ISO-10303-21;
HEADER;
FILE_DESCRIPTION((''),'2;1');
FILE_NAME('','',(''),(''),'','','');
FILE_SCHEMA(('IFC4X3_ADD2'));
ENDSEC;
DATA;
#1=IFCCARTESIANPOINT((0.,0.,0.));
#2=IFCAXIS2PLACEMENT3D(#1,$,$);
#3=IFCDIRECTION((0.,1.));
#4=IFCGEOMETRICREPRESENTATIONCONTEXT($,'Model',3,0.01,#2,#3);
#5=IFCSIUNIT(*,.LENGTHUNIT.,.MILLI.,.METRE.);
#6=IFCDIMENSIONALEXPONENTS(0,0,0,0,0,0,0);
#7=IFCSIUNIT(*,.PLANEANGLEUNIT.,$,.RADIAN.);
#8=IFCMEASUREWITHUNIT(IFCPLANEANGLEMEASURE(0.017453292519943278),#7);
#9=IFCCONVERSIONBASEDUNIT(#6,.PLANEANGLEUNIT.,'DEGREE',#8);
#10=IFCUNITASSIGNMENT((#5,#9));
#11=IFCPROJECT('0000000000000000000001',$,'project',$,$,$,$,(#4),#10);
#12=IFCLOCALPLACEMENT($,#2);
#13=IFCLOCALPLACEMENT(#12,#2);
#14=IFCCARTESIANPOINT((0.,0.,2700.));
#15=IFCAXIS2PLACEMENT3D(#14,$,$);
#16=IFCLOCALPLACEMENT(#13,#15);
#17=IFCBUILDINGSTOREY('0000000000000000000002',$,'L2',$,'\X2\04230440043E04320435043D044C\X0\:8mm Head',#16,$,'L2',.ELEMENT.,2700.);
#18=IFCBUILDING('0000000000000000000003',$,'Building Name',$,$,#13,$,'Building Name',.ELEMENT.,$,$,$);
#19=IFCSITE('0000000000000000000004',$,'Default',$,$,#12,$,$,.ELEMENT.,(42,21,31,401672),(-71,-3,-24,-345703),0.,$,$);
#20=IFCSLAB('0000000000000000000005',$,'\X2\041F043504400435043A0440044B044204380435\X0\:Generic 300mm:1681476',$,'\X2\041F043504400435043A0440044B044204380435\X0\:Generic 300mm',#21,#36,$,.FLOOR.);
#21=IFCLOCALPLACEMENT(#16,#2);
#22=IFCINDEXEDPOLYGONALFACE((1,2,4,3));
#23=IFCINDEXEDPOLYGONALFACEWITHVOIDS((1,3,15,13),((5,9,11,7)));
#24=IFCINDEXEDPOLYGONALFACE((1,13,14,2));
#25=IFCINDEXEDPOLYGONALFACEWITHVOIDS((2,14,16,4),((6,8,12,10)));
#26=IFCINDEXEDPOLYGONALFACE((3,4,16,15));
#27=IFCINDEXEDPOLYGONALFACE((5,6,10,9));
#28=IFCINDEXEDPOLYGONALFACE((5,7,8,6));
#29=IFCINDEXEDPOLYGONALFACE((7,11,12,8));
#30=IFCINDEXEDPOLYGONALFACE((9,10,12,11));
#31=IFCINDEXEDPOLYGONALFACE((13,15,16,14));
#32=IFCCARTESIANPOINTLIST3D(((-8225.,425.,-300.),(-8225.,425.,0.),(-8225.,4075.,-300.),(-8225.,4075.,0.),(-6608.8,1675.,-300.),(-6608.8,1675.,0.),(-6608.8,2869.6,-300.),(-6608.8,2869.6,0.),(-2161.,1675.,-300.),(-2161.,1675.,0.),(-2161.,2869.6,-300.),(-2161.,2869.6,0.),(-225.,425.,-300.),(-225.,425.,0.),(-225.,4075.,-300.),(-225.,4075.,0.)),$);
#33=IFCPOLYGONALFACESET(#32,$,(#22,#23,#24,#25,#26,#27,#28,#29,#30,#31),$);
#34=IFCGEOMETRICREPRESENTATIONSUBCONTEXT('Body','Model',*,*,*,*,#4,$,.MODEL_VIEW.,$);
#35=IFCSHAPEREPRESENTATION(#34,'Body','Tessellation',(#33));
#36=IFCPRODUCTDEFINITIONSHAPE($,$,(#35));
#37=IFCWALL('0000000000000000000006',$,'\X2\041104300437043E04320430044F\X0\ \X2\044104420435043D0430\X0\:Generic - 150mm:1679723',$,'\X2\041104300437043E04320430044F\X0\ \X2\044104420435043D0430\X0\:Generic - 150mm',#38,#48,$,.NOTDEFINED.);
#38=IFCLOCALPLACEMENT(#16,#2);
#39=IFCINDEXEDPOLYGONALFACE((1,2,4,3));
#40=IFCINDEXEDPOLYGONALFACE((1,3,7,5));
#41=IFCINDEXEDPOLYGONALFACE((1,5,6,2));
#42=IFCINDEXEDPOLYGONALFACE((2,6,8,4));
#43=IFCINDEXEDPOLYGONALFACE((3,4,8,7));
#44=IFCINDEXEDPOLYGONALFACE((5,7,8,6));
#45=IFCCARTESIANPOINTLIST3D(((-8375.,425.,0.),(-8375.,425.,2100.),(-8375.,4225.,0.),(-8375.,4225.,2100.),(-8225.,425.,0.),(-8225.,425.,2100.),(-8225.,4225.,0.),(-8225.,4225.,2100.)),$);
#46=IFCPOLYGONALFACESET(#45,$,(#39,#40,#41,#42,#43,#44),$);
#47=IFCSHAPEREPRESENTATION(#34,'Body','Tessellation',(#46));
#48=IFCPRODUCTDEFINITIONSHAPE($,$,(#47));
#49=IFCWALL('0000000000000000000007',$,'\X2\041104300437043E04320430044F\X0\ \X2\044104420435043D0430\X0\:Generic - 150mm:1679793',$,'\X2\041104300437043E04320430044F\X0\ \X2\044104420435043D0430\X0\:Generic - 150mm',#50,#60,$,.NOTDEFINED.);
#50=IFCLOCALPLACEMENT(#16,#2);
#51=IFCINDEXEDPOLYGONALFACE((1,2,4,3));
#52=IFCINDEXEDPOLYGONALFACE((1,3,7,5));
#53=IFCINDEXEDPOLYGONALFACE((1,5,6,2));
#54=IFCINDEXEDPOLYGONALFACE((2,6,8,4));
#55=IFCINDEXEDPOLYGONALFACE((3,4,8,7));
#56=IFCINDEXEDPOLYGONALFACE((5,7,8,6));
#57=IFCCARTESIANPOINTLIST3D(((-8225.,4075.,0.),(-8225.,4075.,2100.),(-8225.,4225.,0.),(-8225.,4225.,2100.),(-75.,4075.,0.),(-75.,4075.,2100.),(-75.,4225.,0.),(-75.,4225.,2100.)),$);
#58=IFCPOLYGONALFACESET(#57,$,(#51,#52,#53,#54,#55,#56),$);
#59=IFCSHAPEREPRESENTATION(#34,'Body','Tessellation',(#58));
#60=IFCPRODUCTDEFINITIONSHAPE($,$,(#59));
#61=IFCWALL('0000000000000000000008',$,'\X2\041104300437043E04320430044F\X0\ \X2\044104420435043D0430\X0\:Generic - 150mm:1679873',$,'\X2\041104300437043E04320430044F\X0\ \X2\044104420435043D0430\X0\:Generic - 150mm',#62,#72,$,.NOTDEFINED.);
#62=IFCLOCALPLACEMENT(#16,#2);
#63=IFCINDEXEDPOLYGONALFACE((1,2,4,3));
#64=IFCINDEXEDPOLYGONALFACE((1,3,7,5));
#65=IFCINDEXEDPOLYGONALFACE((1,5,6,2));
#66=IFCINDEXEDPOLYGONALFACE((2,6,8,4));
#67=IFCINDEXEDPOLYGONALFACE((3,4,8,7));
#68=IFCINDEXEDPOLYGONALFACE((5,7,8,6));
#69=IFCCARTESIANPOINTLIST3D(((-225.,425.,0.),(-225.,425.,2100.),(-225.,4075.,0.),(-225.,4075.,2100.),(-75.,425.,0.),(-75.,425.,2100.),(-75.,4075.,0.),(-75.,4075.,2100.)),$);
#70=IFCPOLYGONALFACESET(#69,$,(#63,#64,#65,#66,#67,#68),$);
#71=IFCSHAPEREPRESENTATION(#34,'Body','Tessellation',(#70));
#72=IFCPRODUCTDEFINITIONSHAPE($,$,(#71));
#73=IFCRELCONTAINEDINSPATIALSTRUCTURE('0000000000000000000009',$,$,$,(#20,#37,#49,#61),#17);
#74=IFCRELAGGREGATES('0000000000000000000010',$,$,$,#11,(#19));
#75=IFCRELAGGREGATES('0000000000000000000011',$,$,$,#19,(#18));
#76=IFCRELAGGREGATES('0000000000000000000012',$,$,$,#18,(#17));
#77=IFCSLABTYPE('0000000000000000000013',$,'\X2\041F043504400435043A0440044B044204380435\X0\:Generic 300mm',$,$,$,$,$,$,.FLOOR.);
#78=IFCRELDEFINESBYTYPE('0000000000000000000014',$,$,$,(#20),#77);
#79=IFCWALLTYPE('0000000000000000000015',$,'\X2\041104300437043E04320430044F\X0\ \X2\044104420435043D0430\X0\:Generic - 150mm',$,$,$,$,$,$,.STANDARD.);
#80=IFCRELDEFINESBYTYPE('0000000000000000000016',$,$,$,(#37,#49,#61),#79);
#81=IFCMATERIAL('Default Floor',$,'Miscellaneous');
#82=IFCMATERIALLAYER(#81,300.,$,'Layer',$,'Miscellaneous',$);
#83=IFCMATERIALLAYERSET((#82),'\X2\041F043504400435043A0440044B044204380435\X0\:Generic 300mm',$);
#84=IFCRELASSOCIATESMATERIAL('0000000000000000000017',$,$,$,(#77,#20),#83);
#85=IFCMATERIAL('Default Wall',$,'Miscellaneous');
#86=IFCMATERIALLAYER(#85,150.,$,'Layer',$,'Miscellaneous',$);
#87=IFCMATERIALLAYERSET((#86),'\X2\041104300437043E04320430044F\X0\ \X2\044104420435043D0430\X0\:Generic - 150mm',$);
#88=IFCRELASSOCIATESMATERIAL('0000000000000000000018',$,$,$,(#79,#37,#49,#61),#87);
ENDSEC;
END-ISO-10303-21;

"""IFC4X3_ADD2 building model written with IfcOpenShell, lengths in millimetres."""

from ifc_helpers import new_model, entity, si_unit, converted_unit, direction, frame, frame_2d, origin, place, context, subcontext, project, spatial, rectangle, extrude, boolean, material, layer, layer_set, layer_usage, type_object, element, save


model = new_model("IFC4X3_ADD2")

# Units and contexts
model_context = context("Model", 3, precision=0.01, world=origin(), true_north=direction((0.0, 1.0)))
body_context = subcontext(model_context, "Body", "Model", "MODEL_VIEW")
ifc_project = project(units=[si_unit("LENGTHUNIT", "METRE", prefix="MILLI"), converted_unit("PLANEANGLEUNIT", "DEGREE", entity("IfcPlaneAngleMeasure", 0.017453292519943278), si_unit("PLANEANGLEUNIT", "RADIAN"), dimensions=[0, 0, 0, 0, 0, 0, 0])], contexts=[model_context])

# Site, building, storey
site_placement = place(None, origin())
site = spatial("IfcSite", under=ifc_project, at=site_placement, Name="Default", CompositionType="ELEMENT", RefLatitude=(42, 21, 31, 401672), RefLongitude=(-71, -3, -24, -345703), RefElevation=0.0)
building_placement = place(site_placement, origin())
building = spatial("IfcBuilding", under=site, at=building_placement, Name="Building Name", LongName="Building Name", CompositionType="ELEMENT")
storey_placement = place(building_placement, frame((0.0, 0.0, 2700.0)))
storey = spatial("IfcBuildingStorey", under=building, at=storey_placement, Name="L2", ObjectType="Уровень:8mm Head", LongName="L2", CompositionType="ELEMENT", Elevation=2700.0)

# Slab, opening
ifc_material_1 = material(Name="Default Floor", Category="Miscellaneous")
ifc_layer_1 = layer(ifc_material_1, 300.0, Name="Layer", Category="Miscellaneous")
ifc_layer_set_1 = layer_set([ifc_layer_1], Name="Перекрытие:Generic 300mm")
ifc_layer_usage = layer_usage(ifc_layer_set_1, "AXIS3", "POSITIVE", 0.0)
slab_type = type_object("IfcSlabType", Name="Перекрытие:Generic 300mm", PredefinedType="FLOOR", material=ifc_layer_set_1)
slab_placement = place(storey_placement, origin())
slab = element("IfcSlab", 1, at=slab_placement, inside=storey, type_object=slab_type, material=ifc_layer_usage, Name="Перекрытие:Generic 300mm:1681476", ObjectType="Перекрытие:Generic 300mm", PredefinedType="FLOOR", context=body_context, shape_type="CSG", body=[
    boolean("DIFFERENCE", extrude(rectangle(XDim=3650.0, YDim=8000.0, at=frame_2d((0.0, 0.0), x_axis=(1.0, 0.0))), frame((-4225.0, 2250.0, 0.0), z_axis=(0.0, 0.0, -1.0), x_axis=(0.0, 1.0, 0.0)), (0.0, 0.0, 1.0), 300.0), extrude(rectangle(XDim=1194.6, YDim=4447.8, at=frame_2d((0.0, 0.0), x_axis=(1.0, 0.0))), frame((-4384.9, 2272.3, -300.0), z_axis=(0.0, 0.0, 1.0), x_axis=(0.0, 1.0, 0.0)), (0.0, 0.0, 1.0), 300.0)),
])
opening_placement = place(slab_placement, origin())
element("IfcOpeningElement", 2, at=opening_placement, cuts=slab, PredefinedType="OPENING", context=body_context, shape_type="SweptSolid", body=[
    extrude(rectangle(XDim=1194.6, YDim=4447.8, at=frame_2d((-4384.9, 2272.3), x_axis=(0.0, -1.0))), origin(), (0.0, 0.0, -1.0), 300.0),
])

# Walls
ifc_material_2 = material(Name="Default Wall", Category="Miscellaneous")
ifc_layer_2 = layer(ifc_material_2, 150.0, Name="Layer", Category="Miscellaneous")
ifc_layer_set_2 = layer_set([ifc_layer_2], Name="Базовая стена:Generic - 150mm")
wall_type = type_object("IfcWallType", Name="Базовая стена:Generic - 150mm", PredefinedType="STANDARD", material=ifc_layer_set_2)
wall_1_placement = place(storey_placement, frame((-8300.0, 425.0, 0.0), z_axis=(0.0, 0.0, 1.0), x_axis=(0.0, 1.0, 0.0)))
element("IfcWall", 3, at=wall_1_placement, inside=storey, type_object=wall_type, material=ifc_layer_set_2, Name="Базовая стена:Generic - 150mm:1679723", ObjectType="Базовая стена:Generic - 150mm", PredefinedType="NOTDEFINED", context=body_context, shape_type="SweptSolid", body=[
    extrude(rectangle(XDim=3800.0, YDim=150.0, at=frame_2d((1900.0, 0.0), x_axis=(-1.0, 0.0))), origin(), (0.0, 0.0, 1.0), 2100.0),
])
wall_2_placement = place(storey_placement, frame((-8225.0, 4150.0, 0.0)))
element("IfcWall", 4, at=wall_2_placement, inside=storey, type_object=wall_type, material=ifc_layer_set_2, Name="Базовая стена:Generic - 150mm:1679793", ObjectType="Базовая стена:Generic - 150mm", PredefinedType="NOTDEFINED", context=body_context, shape_type="SweptSolid", body=[
    extrude(rectangle(XDim=8150.0, YDim=150.0, at=frame_2d((4075.0, 0.0), x_axis=(-1.0, 0.0))), origin(), (0.0, 0.0, 1.0), 2100.0),
])
wall_3_placement = place(storey_placement, frame((-150.0, 4075.0, 0.0), z_axis=(0.0, 0.0, 1.0), x_axis=(0.0, -1.0, 0.0)))
element("IfcWall", 5, at=wall_3_placement, inside=storey, type_object=wall_type, material=ifc_layer_set_2, Name="Базовая стена:Generic - 150mm:1679873", ObjectType="Базовая стена:Generic - 150mm", PredefinedType="NOTDEFINED", context=body_context, shape_type="SweptSolid", body=[
    extrude(rectangle(XDim=3650.0, YDim=150.0, at=frame_2d((1825.0, 0.0), x_axis=(-1.0, 0.0))), origin(), (0.0, 0.0, 1.0), 2100.0),
])

save(model, "model.ifc")
